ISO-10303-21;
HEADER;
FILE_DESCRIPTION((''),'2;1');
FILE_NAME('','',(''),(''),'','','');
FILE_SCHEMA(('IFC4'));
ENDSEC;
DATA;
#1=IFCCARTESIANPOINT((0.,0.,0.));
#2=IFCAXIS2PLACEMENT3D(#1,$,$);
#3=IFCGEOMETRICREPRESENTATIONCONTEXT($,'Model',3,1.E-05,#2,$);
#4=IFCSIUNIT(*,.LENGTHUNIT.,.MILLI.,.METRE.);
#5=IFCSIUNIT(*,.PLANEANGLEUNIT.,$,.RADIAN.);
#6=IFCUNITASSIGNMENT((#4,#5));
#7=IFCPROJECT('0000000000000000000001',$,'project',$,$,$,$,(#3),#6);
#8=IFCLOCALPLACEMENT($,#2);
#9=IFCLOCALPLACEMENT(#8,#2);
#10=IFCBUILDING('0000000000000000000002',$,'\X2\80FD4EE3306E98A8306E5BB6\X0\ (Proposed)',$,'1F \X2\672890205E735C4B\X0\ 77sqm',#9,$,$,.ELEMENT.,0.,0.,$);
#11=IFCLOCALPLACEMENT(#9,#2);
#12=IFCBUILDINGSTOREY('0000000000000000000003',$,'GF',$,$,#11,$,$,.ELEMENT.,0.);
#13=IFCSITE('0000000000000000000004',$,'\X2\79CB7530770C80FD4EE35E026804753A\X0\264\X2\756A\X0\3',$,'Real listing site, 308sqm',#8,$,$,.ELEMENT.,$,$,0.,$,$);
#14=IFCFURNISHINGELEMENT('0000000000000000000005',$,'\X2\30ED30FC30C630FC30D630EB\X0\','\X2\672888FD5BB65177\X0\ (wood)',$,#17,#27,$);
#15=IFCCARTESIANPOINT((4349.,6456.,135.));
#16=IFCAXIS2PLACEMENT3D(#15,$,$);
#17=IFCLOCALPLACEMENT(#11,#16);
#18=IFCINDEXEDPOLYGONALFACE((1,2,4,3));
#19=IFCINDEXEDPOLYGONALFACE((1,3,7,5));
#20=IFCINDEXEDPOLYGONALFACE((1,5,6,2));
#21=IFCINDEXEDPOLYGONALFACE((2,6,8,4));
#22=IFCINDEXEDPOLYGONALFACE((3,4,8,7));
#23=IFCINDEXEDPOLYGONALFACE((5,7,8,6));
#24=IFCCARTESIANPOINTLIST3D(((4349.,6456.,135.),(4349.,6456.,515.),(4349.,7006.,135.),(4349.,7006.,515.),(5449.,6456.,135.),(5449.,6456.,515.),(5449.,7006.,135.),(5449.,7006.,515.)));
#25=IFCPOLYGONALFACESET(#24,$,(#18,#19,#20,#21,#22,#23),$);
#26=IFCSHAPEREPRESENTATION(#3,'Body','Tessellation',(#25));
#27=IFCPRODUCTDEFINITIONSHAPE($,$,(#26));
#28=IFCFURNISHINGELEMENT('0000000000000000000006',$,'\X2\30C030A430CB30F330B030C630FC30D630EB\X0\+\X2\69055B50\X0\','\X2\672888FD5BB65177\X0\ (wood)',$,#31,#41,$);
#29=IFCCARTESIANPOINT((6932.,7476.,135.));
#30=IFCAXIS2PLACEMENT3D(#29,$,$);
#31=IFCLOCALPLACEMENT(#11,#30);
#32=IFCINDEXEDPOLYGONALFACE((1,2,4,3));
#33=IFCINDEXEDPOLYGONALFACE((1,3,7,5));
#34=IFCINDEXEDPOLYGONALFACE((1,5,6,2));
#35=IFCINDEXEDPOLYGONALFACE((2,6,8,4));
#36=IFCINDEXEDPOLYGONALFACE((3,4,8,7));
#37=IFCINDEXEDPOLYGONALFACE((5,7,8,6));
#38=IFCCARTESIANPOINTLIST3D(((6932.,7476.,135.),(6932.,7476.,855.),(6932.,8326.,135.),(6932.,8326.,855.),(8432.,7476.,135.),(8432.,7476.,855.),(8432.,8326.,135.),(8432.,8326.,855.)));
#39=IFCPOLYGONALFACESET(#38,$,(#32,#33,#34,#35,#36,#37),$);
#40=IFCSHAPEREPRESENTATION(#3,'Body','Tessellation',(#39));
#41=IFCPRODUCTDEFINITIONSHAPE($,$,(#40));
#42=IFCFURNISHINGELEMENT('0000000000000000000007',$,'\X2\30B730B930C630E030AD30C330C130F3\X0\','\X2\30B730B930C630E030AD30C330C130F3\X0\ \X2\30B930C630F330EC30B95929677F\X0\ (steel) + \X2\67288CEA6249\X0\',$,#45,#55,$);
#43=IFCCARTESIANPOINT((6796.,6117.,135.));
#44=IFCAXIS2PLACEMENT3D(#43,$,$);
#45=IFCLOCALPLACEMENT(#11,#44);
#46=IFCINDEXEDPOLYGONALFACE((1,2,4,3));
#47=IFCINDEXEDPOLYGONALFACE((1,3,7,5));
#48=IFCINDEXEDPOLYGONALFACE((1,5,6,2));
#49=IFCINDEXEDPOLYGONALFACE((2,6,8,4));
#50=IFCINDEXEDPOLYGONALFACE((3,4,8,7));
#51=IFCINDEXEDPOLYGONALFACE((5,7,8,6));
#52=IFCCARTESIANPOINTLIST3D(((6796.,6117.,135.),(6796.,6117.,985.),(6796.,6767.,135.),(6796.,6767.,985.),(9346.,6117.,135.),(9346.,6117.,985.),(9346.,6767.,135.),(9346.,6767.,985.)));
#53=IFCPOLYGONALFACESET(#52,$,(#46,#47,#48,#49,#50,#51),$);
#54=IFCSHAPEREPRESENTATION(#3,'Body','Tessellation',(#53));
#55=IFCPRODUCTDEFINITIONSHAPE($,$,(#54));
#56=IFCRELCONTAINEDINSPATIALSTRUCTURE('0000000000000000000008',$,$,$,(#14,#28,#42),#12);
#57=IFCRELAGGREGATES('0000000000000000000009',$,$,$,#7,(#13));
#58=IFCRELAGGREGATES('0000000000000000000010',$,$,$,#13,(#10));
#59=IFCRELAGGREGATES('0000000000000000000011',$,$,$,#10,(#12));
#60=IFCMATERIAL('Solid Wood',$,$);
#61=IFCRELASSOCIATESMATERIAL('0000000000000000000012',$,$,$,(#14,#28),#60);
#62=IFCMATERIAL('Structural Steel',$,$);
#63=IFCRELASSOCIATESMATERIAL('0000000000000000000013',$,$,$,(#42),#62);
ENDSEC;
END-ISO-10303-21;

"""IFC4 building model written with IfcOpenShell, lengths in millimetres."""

from ifc_helpers import new_model, si_unit, frame, frame_2d, origin, place, context, project, spatial, rectangle, extrude, material, element, save


model = new_model("IFC4")

# Units and contexts
model_context = context("Model", 3, precision=1e-05, world=origin())
ifc_project = project(units=[si_unit("LENGTHUNIT", "METRE", prefix="MILLI"), si_unit("PLANEANGLEUNIT", "RADIAN")], contexts=[model_context])

# Site, building, storey
site_placement = place(None, origin())
site = spatial("IfcSite", under=ifc_project, at=site_placement, Name="秋田県能代市栄町264番3", ObjectType="Real listing site, 308sqm", CompositionType="ELEMENT", RefElevation=0.0)
building_placement = place(site_placement, origin())
building = spatial("IfcBuilding", under=site, at=building_placement, Name="能代の風の家 (Proposed)", ObjectType="1F 木造平屋 77sqm", CompositionType="ELEMENT", ElevationOfRefHeight=0.0, ElevationOfTerrain=0.0)
storey_placement = place(building_placement, origin())
storey = spatial("IfcBuildingStorey", under=building, at=storey_placement, Name="GF", CompositionType="ELEMENT", Elevation=0.0)

# Shared definitions
ifc_material_1 = material(Name="Solid Wood")

# Shared definitions
ifc_material_2 = material(Name="Structural Steel")

# Furnishing elements
furnishing_1_placement = place(storey_placement, frame((4349.0, 6456.0, 135.0)))
element("IfcFurnishingElement", 1, at=furnishing_1_placement, inside=storey, material=ifc_material_1, Name="ローテーブル", Description="木製家具 (wood)", context=model_context, shape_type="SweptSolid", body=[
    extrude(rectangle(XDim=1100.0, YDim=550.0, at=frame_2d((550.0, 275.0))), frame((4349.0, 6456.0, 135.0)), (0.0, 0.0, 1.0), 380.0),
])
furnishing_2_placement = place(storey_placement, frame((6932.0, 7476.0, 135.0)))
element("IfcFurnishingElement", 2, at=furnishing_2_placement, inside=storey, material=ifc_material_1, Name="ダイニングテーブル+椅子", Description="木製家具 (wood)", context=model_context, shape_type="SweptSolid", body=[
    extrude(rectangle(XDim=1500.0, YDim=850.0, at=frame_2d((750.0, 425.0))), frame((6932.0, 7476.0, 135.0)), (0.0, 0.0, 1.0), 720.0),
])
furnishing_3_placement = place(storey_placement, frame((6796.0, 6117.0, 135.0)))
element("IfcFurnishingElement", 3, at=furnishing_3_placement, inside=storey, material=ifc_material_2, Name="システムキッチン", Description="システムキッチン ステンレス天板 (steel) + 木質扉", context=model_context, shape_type="SweptSolid", body=[
    extrude(rectangle(XDim=2550.0, YDim=650.0, at=frame_2d((1275.0, 325.0))), frame((6796.0, 6117.0, 135.0)), (0.0, 0.0, 1.0), 850.0),
])

save(model, "model.ifc")
